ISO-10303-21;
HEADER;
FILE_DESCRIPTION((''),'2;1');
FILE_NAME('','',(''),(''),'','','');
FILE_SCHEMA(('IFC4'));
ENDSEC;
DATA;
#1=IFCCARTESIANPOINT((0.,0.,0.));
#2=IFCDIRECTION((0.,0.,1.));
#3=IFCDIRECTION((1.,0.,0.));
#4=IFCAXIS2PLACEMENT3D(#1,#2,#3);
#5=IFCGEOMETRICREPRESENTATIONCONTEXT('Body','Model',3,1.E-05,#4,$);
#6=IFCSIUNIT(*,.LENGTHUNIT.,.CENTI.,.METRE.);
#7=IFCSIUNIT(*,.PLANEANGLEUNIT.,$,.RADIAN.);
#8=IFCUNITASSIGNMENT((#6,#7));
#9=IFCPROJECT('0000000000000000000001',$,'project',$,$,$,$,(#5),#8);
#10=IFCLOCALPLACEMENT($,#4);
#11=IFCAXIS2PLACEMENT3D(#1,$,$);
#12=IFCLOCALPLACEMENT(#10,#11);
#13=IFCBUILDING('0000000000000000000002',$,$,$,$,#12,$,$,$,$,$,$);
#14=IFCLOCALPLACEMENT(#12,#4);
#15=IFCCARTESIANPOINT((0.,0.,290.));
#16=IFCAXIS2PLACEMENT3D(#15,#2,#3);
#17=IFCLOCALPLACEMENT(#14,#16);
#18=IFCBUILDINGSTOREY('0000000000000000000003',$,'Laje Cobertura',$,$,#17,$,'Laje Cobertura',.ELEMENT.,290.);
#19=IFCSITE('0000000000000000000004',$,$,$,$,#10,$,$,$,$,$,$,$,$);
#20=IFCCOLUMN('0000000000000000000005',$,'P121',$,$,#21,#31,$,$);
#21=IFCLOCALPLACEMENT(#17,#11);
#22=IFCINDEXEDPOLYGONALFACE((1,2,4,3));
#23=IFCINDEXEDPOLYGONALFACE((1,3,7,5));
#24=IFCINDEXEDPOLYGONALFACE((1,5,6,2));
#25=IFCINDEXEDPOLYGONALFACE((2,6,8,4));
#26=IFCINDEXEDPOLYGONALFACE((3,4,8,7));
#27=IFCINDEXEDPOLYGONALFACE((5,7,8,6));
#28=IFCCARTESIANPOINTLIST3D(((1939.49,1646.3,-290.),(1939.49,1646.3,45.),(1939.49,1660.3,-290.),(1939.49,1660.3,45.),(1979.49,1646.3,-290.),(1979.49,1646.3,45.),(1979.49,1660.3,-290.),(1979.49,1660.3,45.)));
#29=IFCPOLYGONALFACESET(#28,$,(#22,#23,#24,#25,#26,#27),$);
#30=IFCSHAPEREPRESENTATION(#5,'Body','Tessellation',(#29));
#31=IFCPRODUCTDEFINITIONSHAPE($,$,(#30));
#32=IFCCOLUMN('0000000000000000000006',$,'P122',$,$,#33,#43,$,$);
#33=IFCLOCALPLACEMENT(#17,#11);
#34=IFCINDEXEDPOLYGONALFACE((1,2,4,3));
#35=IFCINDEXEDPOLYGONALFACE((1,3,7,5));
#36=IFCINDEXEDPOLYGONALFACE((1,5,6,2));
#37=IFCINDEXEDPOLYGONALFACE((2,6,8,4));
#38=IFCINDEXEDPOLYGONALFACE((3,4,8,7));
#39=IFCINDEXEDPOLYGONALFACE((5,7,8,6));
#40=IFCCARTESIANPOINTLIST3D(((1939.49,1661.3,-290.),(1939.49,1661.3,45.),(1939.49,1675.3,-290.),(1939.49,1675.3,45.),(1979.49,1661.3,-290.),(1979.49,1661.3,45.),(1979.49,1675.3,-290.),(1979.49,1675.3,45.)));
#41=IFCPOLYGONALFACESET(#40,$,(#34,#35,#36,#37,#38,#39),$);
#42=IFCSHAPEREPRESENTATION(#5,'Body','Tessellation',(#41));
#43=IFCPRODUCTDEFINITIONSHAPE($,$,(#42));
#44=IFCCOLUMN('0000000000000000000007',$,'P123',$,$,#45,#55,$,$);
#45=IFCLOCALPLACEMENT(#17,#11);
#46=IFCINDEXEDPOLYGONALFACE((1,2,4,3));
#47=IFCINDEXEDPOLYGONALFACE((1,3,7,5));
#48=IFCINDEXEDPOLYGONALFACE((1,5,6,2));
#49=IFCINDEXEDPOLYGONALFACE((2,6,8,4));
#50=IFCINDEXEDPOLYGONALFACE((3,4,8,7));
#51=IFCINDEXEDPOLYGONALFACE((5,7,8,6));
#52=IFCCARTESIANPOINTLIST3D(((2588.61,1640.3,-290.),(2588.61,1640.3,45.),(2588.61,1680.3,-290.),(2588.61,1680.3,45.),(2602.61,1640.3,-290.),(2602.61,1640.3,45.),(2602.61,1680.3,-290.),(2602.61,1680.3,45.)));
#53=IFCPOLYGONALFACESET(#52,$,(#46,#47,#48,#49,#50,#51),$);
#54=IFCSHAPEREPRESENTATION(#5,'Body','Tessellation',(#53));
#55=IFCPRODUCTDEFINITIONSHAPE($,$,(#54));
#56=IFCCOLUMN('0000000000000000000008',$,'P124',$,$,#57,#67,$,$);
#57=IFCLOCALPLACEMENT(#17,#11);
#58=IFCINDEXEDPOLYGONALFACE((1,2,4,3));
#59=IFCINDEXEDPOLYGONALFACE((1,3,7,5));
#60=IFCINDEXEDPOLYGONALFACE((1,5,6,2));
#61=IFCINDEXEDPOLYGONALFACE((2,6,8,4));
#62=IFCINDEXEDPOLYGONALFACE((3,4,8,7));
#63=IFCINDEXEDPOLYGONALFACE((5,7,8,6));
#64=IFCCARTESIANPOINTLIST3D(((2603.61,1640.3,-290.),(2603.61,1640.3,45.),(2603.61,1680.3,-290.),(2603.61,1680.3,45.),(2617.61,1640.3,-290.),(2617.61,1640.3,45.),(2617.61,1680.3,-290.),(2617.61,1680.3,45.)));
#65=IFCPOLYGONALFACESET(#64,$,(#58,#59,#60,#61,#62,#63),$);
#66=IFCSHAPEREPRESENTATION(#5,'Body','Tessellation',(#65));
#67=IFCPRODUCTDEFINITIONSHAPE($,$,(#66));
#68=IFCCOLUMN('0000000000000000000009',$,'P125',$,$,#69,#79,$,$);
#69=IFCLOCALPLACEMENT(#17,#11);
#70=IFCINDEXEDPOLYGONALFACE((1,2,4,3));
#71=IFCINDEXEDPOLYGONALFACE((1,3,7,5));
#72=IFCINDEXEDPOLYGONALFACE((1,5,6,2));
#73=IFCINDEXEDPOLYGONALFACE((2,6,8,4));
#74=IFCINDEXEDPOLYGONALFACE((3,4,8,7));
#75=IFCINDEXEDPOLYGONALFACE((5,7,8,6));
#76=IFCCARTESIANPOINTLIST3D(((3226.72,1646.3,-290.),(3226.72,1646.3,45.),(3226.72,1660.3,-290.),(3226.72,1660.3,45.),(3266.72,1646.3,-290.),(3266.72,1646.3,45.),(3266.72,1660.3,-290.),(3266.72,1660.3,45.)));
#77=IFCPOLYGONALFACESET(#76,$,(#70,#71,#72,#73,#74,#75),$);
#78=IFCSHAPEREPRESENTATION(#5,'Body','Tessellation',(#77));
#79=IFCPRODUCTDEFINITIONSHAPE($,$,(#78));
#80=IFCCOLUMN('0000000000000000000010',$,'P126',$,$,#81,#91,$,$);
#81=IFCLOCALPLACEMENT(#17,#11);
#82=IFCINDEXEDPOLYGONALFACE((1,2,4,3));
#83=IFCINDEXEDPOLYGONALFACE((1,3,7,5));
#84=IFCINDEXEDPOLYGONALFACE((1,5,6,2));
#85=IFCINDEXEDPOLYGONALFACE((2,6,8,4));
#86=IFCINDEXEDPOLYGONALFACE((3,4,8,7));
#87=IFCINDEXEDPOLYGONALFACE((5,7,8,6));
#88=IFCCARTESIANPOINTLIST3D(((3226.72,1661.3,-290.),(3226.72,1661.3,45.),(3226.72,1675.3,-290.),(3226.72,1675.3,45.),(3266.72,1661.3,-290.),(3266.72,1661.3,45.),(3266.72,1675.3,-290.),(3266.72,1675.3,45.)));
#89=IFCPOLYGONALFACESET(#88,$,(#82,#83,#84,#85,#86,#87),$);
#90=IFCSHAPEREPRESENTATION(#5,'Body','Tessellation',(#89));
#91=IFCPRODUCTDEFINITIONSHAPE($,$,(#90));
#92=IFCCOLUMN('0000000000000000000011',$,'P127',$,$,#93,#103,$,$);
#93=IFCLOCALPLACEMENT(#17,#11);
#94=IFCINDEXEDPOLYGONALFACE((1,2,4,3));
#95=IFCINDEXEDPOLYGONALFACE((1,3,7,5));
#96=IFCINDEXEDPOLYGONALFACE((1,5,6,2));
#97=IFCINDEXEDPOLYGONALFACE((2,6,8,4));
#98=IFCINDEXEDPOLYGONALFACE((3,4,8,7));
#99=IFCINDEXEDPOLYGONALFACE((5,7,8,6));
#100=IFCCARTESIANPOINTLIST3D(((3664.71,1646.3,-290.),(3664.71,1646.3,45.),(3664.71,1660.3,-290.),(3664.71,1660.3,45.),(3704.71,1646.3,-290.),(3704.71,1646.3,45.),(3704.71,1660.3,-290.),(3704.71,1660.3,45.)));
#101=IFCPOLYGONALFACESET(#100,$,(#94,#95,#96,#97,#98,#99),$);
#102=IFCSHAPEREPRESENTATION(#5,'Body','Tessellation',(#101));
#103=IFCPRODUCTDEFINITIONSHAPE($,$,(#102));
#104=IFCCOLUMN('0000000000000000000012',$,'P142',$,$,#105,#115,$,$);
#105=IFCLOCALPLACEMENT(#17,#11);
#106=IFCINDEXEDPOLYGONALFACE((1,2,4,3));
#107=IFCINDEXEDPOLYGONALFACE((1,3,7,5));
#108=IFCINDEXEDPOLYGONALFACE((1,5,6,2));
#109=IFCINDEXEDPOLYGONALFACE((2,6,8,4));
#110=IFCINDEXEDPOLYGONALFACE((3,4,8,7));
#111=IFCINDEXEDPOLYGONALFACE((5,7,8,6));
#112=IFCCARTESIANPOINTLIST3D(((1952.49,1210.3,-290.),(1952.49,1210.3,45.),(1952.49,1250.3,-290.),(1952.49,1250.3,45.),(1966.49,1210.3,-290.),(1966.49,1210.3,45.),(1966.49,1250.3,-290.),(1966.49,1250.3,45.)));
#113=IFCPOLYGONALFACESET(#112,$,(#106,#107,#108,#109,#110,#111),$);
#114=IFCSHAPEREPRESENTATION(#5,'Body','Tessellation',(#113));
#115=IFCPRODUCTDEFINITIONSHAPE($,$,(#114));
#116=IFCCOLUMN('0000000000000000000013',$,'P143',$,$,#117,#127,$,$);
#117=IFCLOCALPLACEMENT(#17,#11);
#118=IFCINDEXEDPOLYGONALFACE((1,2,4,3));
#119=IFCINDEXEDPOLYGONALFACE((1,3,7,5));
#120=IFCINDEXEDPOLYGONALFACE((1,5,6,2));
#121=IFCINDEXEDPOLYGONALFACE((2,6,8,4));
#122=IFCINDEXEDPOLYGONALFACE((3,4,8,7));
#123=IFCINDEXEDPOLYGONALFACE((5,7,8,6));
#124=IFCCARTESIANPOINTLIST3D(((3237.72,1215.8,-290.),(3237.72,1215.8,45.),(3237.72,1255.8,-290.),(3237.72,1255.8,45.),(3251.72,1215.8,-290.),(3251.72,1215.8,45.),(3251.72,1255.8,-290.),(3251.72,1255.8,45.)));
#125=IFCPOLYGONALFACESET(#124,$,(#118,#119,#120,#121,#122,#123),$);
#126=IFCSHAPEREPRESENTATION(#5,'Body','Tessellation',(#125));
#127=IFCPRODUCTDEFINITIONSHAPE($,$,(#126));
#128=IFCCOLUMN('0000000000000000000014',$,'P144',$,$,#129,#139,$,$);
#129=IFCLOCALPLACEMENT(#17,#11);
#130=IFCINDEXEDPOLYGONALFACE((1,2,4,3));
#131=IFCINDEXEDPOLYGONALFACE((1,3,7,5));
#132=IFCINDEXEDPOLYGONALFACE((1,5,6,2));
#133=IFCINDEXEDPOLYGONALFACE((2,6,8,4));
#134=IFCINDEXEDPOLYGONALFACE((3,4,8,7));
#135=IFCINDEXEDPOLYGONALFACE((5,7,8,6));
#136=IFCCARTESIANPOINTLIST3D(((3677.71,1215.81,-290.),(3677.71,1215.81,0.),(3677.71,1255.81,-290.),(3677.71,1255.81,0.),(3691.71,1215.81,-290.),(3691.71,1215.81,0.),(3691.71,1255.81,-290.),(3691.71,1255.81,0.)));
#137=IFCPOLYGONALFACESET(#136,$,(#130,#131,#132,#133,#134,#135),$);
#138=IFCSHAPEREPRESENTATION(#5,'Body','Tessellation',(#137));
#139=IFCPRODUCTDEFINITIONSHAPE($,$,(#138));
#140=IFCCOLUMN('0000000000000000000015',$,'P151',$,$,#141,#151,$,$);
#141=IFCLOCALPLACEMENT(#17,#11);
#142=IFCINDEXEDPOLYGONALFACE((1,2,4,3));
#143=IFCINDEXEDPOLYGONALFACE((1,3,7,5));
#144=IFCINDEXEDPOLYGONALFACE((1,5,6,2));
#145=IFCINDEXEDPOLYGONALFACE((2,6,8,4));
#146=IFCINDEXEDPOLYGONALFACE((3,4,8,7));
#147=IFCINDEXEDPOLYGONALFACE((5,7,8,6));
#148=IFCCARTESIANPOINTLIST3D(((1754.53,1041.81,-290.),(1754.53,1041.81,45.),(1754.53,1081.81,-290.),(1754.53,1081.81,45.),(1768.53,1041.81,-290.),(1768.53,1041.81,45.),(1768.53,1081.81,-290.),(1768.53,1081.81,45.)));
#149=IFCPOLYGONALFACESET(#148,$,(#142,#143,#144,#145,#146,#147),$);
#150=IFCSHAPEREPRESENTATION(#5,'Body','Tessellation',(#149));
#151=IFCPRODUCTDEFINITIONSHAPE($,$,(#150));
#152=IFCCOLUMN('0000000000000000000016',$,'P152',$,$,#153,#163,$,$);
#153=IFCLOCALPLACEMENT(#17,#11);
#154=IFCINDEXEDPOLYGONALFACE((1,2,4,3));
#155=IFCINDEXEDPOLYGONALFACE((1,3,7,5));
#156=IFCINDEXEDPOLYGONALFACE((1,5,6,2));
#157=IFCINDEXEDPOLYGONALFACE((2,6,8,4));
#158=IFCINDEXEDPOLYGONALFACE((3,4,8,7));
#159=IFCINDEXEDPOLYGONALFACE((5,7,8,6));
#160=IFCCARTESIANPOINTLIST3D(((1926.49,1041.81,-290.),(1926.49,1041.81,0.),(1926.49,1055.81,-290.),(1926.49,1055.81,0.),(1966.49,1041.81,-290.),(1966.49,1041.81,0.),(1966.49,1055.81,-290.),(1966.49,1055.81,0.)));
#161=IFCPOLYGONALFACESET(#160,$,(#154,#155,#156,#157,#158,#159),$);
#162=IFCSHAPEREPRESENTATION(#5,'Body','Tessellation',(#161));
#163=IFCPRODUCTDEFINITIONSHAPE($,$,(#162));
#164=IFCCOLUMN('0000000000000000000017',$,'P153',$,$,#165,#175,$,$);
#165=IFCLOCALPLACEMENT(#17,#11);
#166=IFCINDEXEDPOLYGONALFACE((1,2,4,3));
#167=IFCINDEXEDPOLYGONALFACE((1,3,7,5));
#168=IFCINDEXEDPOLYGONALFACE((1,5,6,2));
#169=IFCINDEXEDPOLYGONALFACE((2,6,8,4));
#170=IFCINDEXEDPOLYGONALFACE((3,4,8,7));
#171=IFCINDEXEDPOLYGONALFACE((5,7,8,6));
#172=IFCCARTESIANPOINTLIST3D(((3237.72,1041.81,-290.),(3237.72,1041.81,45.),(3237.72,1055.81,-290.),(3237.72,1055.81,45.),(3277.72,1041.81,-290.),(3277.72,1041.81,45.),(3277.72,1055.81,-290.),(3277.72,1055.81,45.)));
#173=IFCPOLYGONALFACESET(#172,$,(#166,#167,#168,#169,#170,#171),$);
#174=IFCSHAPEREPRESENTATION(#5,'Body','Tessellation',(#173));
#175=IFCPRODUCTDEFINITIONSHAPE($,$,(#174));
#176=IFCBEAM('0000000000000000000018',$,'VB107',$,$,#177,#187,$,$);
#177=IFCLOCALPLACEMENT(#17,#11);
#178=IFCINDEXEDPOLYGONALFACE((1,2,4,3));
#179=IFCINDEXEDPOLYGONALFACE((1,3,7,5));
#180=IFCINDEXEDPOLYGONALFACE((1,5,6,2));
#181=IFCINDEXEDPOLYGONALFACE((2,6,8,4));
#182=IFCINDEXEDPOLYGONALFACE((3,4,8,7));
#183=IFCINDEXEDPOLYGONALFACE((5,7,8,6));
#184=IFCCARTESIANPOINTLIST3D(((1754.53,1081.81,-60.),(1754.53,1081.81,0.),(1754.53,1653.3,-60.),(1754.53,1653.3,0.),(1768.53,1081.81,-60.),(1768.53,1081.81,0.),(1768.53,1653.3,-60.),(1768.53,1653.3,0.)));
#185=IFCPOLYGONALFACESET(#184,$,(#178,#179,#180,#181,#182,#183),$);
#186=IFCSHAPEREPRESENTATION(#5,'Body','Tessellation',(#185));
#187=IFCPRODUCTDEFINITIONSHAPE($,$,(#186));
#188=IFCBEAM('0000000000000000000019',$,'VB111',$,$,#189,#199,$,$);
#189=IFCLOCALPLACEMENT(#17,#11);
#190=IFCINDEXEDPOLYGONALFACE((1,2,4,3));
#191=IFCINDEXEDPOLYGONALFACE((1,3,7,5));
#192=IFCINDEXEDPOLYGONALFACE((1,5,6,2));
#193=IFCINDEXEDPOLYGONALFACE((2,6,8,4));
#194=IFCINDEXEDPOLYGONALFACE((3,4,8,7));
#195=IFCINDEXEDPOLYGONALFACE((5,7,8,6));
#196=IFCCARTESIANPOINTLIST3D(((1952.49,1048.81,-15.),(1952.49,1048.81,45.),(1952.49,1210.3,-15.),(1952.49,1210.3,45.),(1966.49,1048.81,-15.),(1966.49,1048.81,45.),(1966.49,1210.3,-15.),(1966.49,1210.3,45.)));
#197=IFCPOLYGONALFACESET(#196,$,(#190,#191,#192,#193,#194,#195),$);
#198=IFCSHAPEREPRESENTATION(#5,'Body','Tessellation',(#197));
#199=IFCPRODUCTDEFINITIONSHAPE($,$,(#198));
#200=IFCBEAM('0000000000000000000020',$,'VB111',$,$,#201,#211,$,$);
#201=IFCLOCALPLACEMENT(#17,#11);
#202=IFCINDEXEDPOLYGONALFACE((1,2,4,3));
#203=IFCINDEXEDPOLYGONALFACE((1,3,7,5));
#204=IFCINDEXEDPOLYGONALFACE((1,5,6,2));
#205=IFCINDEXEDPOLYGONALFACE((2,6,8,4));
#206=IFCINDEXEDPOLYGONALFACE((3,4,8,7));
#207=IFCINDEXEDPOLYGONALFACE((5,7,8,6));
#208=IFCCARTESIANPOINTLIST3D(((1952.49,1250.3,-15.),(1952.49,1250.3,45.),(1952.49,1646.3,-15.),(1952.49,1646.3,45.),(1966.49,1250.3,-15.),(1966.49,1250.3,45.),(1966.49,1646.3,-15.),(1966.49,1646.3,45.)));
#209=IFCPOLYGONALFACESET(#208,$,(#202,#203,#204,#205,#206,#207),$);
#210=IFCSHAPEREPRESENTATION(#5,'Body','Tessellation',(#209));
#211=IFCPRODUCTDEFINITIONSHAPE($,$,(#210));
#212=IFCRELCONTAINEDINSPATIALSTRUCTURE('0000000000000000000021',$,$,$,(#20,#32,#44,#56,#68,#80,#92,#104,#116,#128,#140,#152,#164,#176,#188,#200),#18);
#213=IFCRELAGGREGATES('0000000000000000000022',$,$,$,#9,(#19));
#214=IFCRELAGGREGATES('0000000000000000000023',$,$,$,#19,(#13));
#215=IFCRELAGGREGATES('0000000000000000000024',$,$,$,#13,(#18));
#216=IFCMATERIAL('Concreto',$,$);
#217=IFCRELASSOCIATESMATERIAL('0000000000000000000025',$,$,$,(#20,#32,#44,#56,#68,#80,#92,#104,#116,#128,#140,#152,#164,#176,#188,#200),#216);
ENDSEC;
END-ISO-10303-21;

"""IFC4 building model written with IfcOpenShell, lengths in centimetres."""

from ifc_helpers import new_model, si_unit, frame, origin, origin_with_axes, origin_2d_with_axis, place, context, project, spatial, rectangle, extrude, material, element, save


model = new_model("IFC4")

# Units and contexts
model_context = context("Model", 3, precision=1e-05, world=origin_with_axes(), identifier="Body")
ifc_project = project(units=[si_unit("LENGTHUNIT", "METRE", prefix="CENTI"), si_unit("PLANEANGLEUNIT", "RADIAN")], contexts=[model_context])

# Site, building, storey
site_placement = place(None, origin_with_axes())
site = spatial("IfcSite", under=ifc_project, at=site_placement)
building_placement = place(site_placement, origin())
building = spatial("IfcBuilding", under=site, at=building_placement)
placement = place(building_placement, origin_with_axes())
storey_placement = place(placement, frame((0.0, 0.0, 290.0), z_axis=(0.0, 0.0, 1.0), x_axis=(1.0, 0.0, 0.0)))
storey = spatial("IfcBuildingStorey", under=building, at=storey_placement, Name="Laje Cobertura", LongName="Laje Cobertura", CompositionType="ELEMENT", Elevation=290.0)

# Columns
ifc_material = material(Name="Concreto")
for number, where, z_axis, x_axis, name in (
    (1, (1959.49, 1653.3, 45.0), (0.0, 0.0, 1.0), (1.0, 0.0, 0.0), "P121"),
    (2, (1959.49, 1668.3, 45.0), (0.0, 0.0, 1.0), (1.0, 0.0, 0.0), "P122"),
):
    element("IfcColumn", number, at=place(storey_placement, frame(where, z_axis=z_axis, x_axis=x_axis)), inside=storey, material=ifc_material, Name=name, context=model_context, shape_type="SolidModel", body=[
        extrude(rectangle(XDim=14.0, YDim=40.0, at=origin_2d_with_axis()), frame((0.0, 0.0, 0.0), z_axis=(0.0, 0.0, 1.0), x_axis=(0.0, -1.0, 0.0)), (0.0, 0.0, -1.0), 335.0),
    ])
for number, where, z_axis, x_axis, name in (
    (3, (2595.61, 1660.3, 45.0), (0.0, 0.0, 1.0), (1.0, 0.0, 0.0), "P123"),
    (4, (2610.61, 1660.3, 45.0), (0.0, 0.0, 1.0), (1.0, 0.0, 0.0), "P124"),
):
    element("IfcColumn", number, at=place(storey_placement, frame(where, z_axis=z_axis, x_axis=x_axis)), inside=storey, material=ifc_material, Name=name, context=model_context, shape_type="SolidModel", body=[
        extrude(rectangle(XDim=14.0, YDim=40.0, at=origin_2d_with_axis()), origin_with_axes(), (0.0, 0.0, -1.0), 335.0),
    ])
for number, where, z_axis, x_axis, name in (
    (5, (3246.72, 1653.3, 45.0), (0.0, 0.0, 1.0), (1.0, 0.0, 0.0), "P125"),
    (6, (3246.72, 1668.3, 45.0), (0.0, 0.0, 1.0), (1.0, 0.0, 0.0), "P126"),
    (7, (3684.71, 1653.3, 45.0), (0.0, 0.0, 1.0), (1.0, 0.0, 0.0), "P127"),
):
    element("IfcColumn", number, at=place(storey_placement, frame(where, z_axis=z_axis, x_axis=x_axis)), inside=storey, material=ifc_material, Name=name, context=model_context, shape_type="SolidModel", body=[
        extrude(rectangle(XDim=14.0, YDim=40.0, at=origin_2d_with_axis()), frame((0.0, 0.0, 0.0), z_axis=(0.0, 0.0, 1.0), x_axis=(0.0, -1.0, 0.0)), (0.0, 0.0, -1.0), 335.0),
    ])
for number, where, z_axis, x_axis, name in (
    (8, (1959.49, 1230.3, 45.0), (0.0, 0.0, 1.0), (1.0, 0.0, 0.0), "P142"),
    (9, (3244.72, 1235.8, 45.0), (0.0, 0.0, 1.0), (1.0, 0.0, 0.0), "P143"),
):
    element("IfcColumn", number, at=place(storey_placement, frame(where, z_axis=z_axis, x_axis=x_axis)), inside=storey, material=ifc_material, Name=name, context=model_context, shape_type="SolidModel", body=[
        extrude(rectangle(XDim=14.0, YDim=40.0, at=origin_2d_with_axis()), origin_with_axes(), (0.0, 0.0, -1.0), 335.0),
    ])
column_1_placement = place(storey_placement, frame((3684.71, 1235.81, 0.0), z_axis=(0.0, 0.0, 1.0), x_axis=(1.0, 0.0, 0.0)))
element("IfcColumn", 10, at=column_1_placement, inside=storey, material=ifc_material, Name="P144", context=model_context, shape_type="SolidModel", body=[
    extrude(rectangle(XDim=14.0, YDim=40.0, at=origin_2d_with_axis()), origin_with_axes(), (0.0, 0.0, -1.0), 290.0),
])
column_2_placement = place(storey_placement, frame((1761.53, 1061.81, 45.0), z_axis=(0.0, 0.0, 1.0), x_axis=(1.0, 0.0, 0.0)))
element("IfcColumn", 11, at=column_2_placement, inside=storey, material=ifc_material, Name="P151", context=model_context, shape_type="SolidModel", body=[
    extrude(rectangle(XDim=14.0, YDim=40.0, at=origin_2d_with_axis()), origin_with_axes(), (0.0, 0.0, -1.0), 335.0),
])
column_3_placement = place(storey_placement, frame((1946.49, 1048.81, 0.0), z_axis=(0.0, 0.0, 1.0), x_axis=(1.0, 0.0, 0.0)))
element("IfcColumn", 12, at=column_3_placement, inside=storey, material=ifc_material, Name="P152", context=model_context, shape_type="SolidModel", body=[
    extrude(rectangle(XDim=14.0, YDim=40.0, at=origin_2d_with_axis()), frame((0.0, 0.0, 0.0), z_axis=(0.0, 0.0, 1.0), x_axis=(0.0, -1.0, 0.0)), (0.0, 0.0, -1.0), 290.0),
])
column_4_placement = place(storey_placement, frame((3257.72, 1048.81, 45.0), z_axis=(0.0, 0.0, 1.0), x_axis=(1.0, 0.0, 0.0)))
element("IfcColumn", 13, at=column_4_placement, inside=storey, material=ifc_material, Name="P153", context=model_context, shape_type="SolidModel", body=[
    extrude(rectangle(XDim=14.0, YDim=40.0, at=origin_2d_with_axis()), frame((0.0, 0.0, 0.0), z_axis=(0.0, 0.0, 1.0), x_axis=(0.0, -1.0, 0.0)), (0.0, 0.0, -1.0), 335.0),
])

# Beams
beam_1_placement = place(storey_placement, frame((1761.53, 1367.56, 0.0), z_axis=(0.0, 0.0, 1.0), x_axis=(1.0, 0.0, 0.0)))
element("IfcBeam", 14, at=beam_1_placement, inside=storey, material=ifc_material, Name="VB107", context=model_context, shape_type="SolidModel", body=[
    extrude(rectangle(XDim=14.0, YDim=60.0, at=origin_2d_with_axis()), frame((0.0, -285.75, -30.0), z_axis=(0.0, 1.0, 0.0), x_axis=(1.0, 0.0, 0.0)), (0.0, 0.0, 1.0), 571.49),
])
beam_2_placement = place(storey_placement, frame((1959.49, 1129.56, 45.0), z_axis=(0.0, 0.0, 1.0), x_axis=(1.0, 0.0, 0.0)))
element("IfcBeam", 15, at=beam_2_placement, inside=storey, material=ifc_material, Name="VB111", context=model_context, shape_type="SolidModel", body=[
    extrude(rectangle(XDim=14.0, YDim=60.0, at=origin_2d_with_axis()), frame((0.0, -80.75, -30.0), z_axis=(0.0, 1.0, 0.0), x_axis=(1.0, 0.0, 0.0)), (0.0, 0.0, 1.0), 161.49),
])
beam_3_placement = place(storey_placement, frame((1959.49, 1448.3, 45.0), z_axis=(0.0, 0.0, 1.0), x_axis=(1.0, 0.0, 0.0)))
element("IfcBeam", 16, at=beam_3_placement, inside=storey, material=ifc_material, Name="VB111", context=model_context, shape_type="SolidModel", body=[
    extrude(rectangle(XDim=14.0, YDim=60.0, at=origin_2d_with_axis()), frame((0.0, -198.0, -30.0), z_axis=(0.0, 1.0, 0.0), x_axis=(1.0, 0.0, 0.0)), (0.0, 0.0, 1.0), 396.0),
])

save(model, "model.ifc")
